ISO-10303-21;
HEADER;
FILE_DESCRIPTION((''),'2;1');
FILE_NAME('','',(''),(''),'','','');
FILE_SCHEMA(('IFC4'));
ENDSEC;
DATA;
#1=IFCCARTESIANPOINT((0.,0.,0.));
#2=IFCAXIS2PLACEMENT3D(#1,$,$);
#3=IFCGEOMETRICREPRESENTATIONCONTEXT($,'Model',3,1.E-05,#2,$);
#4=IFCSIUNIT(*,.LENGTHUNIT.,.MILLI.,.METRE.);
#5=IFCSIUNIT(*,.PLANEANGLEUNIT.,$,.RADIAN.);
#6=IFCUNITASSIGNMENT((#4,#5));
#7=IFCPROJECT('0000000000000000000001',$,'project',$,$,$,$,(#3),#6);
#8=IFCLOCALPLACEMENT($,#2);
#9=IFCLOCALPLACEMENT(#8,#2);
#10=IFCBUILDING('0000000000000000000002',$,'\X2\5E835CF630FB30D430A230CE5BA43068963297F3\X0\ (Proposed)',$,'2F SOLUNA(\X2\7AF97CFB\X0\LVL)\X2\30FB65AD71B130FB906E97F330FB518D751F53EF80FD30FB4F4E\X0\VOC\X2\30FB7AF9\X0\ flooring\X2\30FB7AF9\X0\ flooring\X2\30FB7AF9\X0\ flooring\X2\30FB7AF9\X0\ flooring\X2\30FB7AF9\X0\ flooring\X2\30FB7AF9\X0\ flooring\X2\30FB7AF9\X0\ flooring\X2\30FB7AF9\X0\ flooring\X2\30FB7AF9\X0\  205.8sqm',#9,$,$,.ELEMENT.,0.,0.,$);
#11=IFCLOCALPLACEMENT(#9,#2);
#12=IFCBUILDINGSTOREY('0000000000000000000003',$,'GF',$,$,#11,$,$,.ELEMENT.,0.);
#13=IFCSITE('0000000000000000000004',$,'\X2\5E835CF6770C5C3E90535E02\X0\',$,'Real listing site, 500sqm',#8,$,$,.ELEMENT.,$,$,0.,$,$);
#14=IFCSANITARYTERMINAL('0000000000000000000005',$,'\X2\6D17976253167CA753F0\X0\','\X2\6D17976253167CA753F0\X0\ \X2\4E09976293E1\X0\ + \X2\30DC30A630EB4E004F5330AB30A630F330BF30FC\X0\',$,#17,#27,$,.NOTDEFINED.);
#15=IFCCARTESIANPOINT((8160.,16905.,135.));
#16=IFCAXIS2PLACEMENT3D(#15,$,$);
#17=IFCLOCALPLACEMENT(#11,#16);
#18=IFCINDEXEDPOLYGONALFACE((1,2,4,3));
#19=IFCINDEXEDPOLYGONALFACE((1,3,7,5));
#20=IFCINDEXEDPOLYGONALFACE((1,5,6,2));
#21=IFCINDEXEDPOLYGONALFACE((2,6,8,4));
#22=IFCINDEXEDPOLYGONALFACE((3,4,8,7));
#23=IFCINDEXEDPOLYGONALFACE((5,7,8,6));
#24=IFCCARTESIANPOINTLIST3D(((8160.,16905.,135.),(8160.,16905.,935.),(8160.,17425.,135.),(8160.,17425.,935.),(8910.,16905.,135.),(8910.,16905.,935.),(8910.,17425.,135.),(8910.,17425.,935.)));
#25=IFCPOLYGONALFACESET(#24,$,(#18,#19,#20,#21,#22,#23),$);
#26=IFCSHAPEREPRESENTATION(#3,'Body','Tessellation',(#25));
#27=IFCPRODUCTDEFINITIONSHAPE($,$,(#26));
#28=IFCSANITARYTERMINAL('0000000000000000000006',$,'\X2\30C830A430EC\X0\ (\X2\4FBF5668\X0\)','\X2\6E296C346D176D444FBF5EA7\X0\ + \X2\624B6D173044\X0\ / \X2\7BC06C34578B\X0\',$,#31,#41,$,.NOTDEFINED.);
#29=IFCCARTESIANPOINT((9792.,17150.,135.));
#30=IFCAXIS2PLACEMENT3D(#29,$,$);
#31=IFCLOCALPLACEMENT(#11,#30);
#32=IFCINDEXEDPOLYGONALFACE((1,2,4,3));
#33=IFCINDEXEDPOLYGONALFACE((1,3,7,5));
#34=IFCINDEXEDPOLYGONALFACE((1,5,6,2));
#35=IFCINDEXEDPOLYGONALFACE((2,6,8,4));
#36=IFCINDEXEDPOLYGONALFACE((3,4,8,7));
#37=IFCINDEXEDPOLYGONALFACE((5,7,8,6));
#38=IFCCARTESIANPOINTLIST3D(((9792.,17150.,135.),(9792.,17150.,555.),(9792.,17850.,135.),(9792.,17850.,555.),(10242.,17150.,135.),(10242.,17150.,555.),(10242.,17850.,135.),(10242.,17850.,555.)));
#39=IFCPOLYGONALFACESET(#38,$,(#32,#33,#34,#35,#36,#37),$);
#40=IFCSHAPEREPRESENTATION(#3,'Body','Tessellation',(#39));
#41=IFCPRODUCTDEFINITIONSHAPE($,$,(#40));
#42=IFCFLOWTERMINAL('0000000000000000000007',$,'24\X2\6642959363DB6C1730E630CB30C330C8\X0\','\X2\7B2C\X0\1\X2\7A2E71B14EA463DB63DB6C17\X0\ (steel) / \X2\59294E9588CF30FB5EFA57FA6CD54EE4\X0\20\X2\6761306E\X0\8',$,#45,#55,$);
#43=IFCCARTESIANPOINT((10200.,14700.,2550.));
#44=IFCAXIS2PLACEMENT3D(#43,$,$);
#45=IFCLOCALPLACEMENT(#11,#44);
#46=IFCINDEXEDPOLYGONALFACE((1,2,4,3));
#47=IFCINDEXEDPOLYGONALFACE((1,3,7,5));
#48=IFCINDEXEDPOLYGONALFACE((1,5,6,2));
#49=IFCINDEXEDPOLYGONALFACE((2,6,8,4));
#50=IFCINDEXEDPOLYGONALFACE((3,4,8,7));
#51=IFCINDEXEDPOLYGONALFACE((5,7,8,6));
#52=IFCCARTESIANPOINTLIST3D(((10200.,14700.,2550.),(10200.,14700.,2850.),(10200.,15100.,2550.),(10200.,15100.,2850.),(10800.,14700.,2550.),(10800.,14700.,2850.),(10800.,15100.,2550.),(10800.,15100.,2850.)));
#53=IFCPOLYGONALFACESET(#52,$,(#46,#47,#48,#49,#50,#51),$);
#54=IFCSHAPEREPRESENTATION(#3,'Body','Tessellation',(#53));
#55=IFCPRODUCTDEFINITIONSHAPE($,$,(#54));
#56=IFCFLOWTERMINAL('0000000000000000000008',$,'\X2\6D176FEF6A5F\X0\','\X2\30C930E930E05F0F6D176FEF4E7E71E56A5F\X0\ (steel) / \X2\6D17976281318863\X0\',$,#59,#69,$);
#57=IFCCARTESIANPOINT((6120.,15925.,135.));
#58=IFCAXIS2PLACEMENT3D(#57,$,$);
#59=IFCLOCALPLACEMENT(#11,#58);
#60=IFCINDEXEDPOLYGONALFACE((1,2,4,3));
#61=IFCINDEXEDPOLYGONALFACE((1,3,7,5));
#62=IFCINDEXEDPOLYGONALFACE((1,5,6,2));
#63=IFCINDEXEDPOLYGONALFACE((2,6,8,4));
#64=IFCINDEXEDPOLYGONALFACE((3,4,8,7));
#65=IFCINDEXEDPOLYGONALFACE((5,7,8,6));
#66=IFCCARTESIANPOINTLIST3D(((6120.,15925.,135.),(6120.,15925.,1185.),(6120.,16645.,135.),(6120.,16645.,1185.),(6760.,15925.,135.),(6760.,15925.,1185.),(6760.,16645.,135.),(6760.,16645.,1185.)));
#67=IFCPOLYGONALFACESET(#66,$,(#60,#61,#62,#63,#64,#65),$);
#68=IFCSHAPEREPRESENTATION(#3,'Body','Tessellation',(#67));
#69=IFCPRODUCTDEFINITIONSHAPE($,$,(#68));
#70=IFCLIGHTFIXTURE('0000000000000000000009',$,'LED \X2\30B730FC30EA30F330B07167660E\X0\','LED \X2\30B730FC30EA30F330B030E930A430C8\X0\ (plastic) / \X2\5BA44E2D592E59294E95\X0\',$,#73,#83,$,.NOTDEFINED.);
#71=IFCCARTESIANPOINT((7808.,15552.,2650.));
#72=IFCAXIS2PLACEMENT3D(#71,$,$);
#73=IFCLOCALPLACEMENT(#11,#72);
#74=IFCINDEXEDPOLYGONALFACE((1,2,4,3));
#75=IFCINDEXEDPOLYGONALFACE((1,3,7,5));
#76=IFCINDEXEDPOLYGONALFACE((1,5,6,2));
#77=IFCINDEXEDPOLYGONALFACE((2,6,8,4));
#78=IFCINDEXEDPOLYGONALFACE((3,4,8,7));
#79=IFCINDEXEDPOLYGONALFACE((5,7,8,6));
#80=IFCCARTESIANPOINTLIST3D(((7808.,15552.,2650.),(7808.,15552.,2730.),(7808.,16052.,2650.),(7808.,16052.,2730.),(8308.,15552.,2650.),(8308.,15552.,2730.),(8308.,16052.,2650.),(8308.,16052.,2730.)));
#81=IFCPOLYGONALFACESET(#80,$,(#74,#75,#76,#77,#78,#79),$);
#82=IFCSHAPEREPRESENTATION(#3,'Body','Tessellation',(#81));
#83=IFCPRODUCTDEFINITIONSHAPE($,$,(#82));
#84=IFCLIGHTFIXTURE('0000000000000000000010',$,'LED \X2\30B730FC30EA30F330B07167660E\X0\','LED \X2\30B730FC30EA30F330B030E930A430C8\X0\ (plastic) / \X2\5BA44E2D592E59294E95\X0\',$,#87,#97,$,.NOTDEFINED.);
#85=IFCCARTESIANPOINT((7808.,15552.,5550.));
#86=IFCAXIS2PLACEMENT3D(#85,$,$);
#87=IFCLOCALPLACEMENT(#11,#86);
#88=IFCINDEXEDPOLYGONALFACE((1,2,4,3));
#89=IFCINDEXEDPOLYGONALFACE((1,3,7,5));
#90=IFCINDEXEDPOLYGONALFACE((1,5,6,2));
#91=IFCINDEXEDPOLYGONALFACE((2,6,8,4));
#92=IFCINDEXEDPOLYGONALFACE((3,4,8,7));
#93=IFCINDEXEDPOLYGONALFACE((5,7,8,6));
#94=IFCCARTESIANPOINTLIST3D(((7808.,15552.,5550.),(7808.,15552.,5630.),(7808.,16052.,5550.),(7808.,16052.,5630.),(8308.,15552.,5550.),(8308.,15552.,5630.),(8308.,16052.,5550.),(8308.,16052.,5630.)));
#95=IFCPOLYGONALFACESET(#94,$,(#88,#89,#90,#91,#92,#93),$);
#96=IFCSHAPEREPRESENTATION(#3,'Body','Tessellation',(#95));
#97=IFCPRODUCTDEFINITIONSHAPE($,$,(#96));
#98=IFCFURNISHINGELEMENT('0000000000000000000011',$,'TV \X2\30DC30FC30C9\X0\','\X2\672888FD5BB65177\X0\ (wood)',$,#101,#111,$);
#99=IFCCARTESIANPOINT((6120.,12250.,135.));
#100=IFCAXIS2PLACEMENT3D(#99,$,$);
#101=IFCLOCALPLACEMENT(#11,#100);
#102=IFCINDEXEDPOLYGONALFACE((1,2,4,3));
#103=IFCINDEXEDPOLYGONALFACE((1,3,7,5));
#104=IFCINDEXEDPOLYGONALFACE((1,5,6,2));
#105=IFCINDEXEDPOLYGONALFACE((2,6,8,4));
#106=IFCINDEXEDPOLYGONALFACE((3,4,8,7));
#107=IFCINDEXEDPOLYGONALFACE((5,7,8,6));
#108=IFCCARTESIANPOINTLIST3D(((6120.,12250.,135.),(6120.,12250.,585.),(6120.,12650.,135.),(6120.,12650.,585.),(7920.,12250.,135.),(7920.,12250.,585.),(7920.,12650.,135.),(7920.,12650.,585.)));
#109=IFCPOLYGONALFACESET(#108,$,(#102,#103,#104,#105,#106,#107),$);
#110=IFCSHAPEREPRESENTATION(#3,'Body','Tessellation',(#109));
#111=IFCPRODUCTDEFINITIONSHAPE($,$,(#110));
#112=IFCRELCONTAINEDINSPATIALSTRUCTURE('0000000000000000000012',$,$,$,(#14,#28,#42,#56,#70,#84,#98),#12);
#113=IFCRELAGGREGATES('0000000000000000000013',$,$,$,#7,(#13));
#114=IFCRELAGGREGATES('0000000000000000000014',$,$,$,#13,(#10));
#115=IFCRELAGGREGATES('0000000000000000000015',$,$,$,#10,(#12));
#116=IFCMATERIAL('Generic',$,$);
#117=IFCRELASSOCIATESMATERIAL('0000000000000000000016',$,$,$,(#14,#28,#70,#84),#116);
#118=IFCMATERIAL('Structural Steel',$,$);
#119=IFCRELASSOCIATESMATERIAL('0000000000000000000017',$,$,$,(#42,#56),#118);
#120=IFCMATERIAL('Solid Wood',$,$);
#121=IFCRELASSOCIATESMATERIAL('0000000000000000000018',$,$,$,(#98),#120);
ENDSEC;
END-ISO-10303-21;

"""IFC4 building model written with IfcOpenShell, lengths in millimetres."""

from ifc_helpers import new_model, si_unit, frame, frame_2d, origin, place, context, project, spatial, rectangle, extrude, material, element, save


model = new_model("IFC4")

# Units and contexts
model_context = context("Model", 3, precision=1e-05, world=origin())
ifc_project = project(units=[si_unit("LENGTHUNIT", "METRE", prefix="MILLI"), si_unit("PLANEANGLEUNIT", "RADIAN")], contexts=[model_context])

# Site, building, storey
site_placement = place(None, origin())
site = spatial("IfcSite", under=ifc_project, at=site_placement, Name="広島県尾道市", ObjectType="Real listing site, 500sqm", CompositionType="ELEMENT", RefElevation=0.0)
building_placement = place(site_placement, origin())
building = spatial("IfcBuilding", under=site, at=building_placement, Name="広島・ピアノ室と防音 (Proposed)", ObjectType="2F SOLUNA(竹系LVL)・断熱・遮音・再生可能・低VOC・竹 flooring・竹 flooring・竹 flooring・竹 flooring・竹 flooring・竹 flooring・竹 flooring・竹 flooring・竹  205.8sqm", CompositionType="ELEMENT", ElevationOfRefHeight=0.0, ElevationOfTerrain=0.0)
storey_placement = place(building_placement, origin())
storey = spatial("IfcBuildingStorey", under=building, at=storey_placement, Name="GF", CompositionType="ELEMENT", Elevation=0.0)

# Shared definitions
ifc_material_1 = material(Name="Solid Wood")

# Sanitary terminals
ifc_material_2 = material(Name="Generic")
sanitary_terminal_1_placement = place(storey_placement, frame((8160.0, 16905.0, 135.0)))
element("IfcSanitaryTerminal", 1, at=sanitary_terminal_1_placement, inside=storey, material=ifc_material_2, Name="洗面化粧台", Description="洗面化粧台 三面鏡 + ボウル一体カウンター", PredefinedType="NOTDEFINED", context=model_context, shape_type="SweptSolid", body=[
    extrude(rectangle(XDim=750.0, YDim=520.0, at=frame_2d((375.0, 260.0))), frame((8160.0, 16905.0, 135.0)), (0.0, 0.0, 1.0), 800.0),
])
sanitary_terminal_2_placement = place(storey_placement, frame((9792.0, 17150.0, 135.0)))
element("IfcSanitaryTerminal", 2, at=sanitary_terminal_2_placement, inside=storey, material=ifc_material_2, Name="トイレ (便器)", Description="温水洗浄便座 + 手洗い / 節水型", PredefinedType="NOTDEFINED", context=model_context, shape_type="SweptSolid", body=[
    extrude(rectangle(XDim=450.0, YDim=700.0, at=frame_2d((225.0, 350.0))), frame((9792.0, 17150.0, 135.0)), (0.0, 0.0, 1.0), 420.0),
])

# Flow terminals
ifc_material_3 = material(Name="Structural Steel")
flow_terminal_1_placement = place(storey_placement, frame((10200.0, 14700.0, 2550.0)))
element("IfcFlowTerminal", 3, at=flow_terminal_1_placement, inside=storey, material=ifc_material_3, Name="24時間換気ユニット", Description="第1種熱交換換気 (steel) / 天井裏・建基法令20条の8", context=model_context, shape_type="SweptSolid", body=[
    extrude(rectangle(XDim=600.0, YDim=400.0, at=frame_2d((300.0, 200.0))), frame((10200.0, 14700.0, 2550.0)), (0.0, 0.0, 1.0), 300.0),
])
flow_terminal_2_placement = place(storey_placement, frame((6120.0, 15925.0, 135.0)))
element("IfcFlowTerminal", 4, at=flow_terminal_2_placement, inside=storey, material=ifc_material_3, Name="洗濯機", Description="ドラム式洗濯乾燥機 (steel) / 洗面脱衣", context=model_context, shape_type="SweptSolid", body=[
    extrude(rectangle(XDim=640.0, YDim=720.0, at=frame_2d((320.0, 360.0))), frame((6120.0, 15925.0, 135.0)), (0.0, 0.0, 1.0), 1050.0),
])

# Light fixtures
light_fixture_1_placement = place(storey_placement, frame((7808.0, 15552.0, 2650.0)))
element("IfcLightFixture", 5, at=light_fixture_1_placement, inside=storey, material=ifc_material_2, Name="LED シーリング照明", Description="LED シーリングライト (plastic) / 室中央天井", PredefinedType="NOTDEFINED", context=model_context, shape_type="SweptSolid", body=[
    extrude(rectangle(XDim=500.0, YDim=500.0, at=frame_2d((250.0, 250.0))), frame((7808.0, 15552.0, 2650.0)), (0.0, 0.0, 1.0), 80.0),
])
light_fixture_2_placement = place(storey_placement, frame((7808.0, 15552.0, 5550.0)))
element("IfcLightFixture", 6, at=light_fixture_2_placement, inside=storey, material=ifc_material_2, Name="LED シーリング照明", Description="LED シーリングライト (plastic) / 室中央天井", PredefinedType="NOTDEFINED", context=model_context, shape_type="SweptSolid", body=[
    extrude(rectangle(XDim=500.0, YDim=500.0, at=frame_2d((250.0, 250.0))), frame((7808.0, 15552.0, 5550.0)), (0.0, 0.0, 1.0), 80.0),
])

# Furnishing element
furnishing_placement = place(storey_placement, frame((6120.0, 12250.0, 135.0)))
element("IfcFurnishingElement", 7, at=furnishing_placement, inside=storey, material=ifc_material_1, Name="TV ボード", Description="木製家具 (wood)", context=model_context, shape_type="SweptSolid", body=[
    extrude(rectangle(XDim=1800.0, YDim=400.0, at=frame_2d((900.0, 200.0))), frame((6120.0, 12250.0, 135.0)), (0.0, 0.0, 1.0), 450.0),
])

save(model, "model.ifc")
